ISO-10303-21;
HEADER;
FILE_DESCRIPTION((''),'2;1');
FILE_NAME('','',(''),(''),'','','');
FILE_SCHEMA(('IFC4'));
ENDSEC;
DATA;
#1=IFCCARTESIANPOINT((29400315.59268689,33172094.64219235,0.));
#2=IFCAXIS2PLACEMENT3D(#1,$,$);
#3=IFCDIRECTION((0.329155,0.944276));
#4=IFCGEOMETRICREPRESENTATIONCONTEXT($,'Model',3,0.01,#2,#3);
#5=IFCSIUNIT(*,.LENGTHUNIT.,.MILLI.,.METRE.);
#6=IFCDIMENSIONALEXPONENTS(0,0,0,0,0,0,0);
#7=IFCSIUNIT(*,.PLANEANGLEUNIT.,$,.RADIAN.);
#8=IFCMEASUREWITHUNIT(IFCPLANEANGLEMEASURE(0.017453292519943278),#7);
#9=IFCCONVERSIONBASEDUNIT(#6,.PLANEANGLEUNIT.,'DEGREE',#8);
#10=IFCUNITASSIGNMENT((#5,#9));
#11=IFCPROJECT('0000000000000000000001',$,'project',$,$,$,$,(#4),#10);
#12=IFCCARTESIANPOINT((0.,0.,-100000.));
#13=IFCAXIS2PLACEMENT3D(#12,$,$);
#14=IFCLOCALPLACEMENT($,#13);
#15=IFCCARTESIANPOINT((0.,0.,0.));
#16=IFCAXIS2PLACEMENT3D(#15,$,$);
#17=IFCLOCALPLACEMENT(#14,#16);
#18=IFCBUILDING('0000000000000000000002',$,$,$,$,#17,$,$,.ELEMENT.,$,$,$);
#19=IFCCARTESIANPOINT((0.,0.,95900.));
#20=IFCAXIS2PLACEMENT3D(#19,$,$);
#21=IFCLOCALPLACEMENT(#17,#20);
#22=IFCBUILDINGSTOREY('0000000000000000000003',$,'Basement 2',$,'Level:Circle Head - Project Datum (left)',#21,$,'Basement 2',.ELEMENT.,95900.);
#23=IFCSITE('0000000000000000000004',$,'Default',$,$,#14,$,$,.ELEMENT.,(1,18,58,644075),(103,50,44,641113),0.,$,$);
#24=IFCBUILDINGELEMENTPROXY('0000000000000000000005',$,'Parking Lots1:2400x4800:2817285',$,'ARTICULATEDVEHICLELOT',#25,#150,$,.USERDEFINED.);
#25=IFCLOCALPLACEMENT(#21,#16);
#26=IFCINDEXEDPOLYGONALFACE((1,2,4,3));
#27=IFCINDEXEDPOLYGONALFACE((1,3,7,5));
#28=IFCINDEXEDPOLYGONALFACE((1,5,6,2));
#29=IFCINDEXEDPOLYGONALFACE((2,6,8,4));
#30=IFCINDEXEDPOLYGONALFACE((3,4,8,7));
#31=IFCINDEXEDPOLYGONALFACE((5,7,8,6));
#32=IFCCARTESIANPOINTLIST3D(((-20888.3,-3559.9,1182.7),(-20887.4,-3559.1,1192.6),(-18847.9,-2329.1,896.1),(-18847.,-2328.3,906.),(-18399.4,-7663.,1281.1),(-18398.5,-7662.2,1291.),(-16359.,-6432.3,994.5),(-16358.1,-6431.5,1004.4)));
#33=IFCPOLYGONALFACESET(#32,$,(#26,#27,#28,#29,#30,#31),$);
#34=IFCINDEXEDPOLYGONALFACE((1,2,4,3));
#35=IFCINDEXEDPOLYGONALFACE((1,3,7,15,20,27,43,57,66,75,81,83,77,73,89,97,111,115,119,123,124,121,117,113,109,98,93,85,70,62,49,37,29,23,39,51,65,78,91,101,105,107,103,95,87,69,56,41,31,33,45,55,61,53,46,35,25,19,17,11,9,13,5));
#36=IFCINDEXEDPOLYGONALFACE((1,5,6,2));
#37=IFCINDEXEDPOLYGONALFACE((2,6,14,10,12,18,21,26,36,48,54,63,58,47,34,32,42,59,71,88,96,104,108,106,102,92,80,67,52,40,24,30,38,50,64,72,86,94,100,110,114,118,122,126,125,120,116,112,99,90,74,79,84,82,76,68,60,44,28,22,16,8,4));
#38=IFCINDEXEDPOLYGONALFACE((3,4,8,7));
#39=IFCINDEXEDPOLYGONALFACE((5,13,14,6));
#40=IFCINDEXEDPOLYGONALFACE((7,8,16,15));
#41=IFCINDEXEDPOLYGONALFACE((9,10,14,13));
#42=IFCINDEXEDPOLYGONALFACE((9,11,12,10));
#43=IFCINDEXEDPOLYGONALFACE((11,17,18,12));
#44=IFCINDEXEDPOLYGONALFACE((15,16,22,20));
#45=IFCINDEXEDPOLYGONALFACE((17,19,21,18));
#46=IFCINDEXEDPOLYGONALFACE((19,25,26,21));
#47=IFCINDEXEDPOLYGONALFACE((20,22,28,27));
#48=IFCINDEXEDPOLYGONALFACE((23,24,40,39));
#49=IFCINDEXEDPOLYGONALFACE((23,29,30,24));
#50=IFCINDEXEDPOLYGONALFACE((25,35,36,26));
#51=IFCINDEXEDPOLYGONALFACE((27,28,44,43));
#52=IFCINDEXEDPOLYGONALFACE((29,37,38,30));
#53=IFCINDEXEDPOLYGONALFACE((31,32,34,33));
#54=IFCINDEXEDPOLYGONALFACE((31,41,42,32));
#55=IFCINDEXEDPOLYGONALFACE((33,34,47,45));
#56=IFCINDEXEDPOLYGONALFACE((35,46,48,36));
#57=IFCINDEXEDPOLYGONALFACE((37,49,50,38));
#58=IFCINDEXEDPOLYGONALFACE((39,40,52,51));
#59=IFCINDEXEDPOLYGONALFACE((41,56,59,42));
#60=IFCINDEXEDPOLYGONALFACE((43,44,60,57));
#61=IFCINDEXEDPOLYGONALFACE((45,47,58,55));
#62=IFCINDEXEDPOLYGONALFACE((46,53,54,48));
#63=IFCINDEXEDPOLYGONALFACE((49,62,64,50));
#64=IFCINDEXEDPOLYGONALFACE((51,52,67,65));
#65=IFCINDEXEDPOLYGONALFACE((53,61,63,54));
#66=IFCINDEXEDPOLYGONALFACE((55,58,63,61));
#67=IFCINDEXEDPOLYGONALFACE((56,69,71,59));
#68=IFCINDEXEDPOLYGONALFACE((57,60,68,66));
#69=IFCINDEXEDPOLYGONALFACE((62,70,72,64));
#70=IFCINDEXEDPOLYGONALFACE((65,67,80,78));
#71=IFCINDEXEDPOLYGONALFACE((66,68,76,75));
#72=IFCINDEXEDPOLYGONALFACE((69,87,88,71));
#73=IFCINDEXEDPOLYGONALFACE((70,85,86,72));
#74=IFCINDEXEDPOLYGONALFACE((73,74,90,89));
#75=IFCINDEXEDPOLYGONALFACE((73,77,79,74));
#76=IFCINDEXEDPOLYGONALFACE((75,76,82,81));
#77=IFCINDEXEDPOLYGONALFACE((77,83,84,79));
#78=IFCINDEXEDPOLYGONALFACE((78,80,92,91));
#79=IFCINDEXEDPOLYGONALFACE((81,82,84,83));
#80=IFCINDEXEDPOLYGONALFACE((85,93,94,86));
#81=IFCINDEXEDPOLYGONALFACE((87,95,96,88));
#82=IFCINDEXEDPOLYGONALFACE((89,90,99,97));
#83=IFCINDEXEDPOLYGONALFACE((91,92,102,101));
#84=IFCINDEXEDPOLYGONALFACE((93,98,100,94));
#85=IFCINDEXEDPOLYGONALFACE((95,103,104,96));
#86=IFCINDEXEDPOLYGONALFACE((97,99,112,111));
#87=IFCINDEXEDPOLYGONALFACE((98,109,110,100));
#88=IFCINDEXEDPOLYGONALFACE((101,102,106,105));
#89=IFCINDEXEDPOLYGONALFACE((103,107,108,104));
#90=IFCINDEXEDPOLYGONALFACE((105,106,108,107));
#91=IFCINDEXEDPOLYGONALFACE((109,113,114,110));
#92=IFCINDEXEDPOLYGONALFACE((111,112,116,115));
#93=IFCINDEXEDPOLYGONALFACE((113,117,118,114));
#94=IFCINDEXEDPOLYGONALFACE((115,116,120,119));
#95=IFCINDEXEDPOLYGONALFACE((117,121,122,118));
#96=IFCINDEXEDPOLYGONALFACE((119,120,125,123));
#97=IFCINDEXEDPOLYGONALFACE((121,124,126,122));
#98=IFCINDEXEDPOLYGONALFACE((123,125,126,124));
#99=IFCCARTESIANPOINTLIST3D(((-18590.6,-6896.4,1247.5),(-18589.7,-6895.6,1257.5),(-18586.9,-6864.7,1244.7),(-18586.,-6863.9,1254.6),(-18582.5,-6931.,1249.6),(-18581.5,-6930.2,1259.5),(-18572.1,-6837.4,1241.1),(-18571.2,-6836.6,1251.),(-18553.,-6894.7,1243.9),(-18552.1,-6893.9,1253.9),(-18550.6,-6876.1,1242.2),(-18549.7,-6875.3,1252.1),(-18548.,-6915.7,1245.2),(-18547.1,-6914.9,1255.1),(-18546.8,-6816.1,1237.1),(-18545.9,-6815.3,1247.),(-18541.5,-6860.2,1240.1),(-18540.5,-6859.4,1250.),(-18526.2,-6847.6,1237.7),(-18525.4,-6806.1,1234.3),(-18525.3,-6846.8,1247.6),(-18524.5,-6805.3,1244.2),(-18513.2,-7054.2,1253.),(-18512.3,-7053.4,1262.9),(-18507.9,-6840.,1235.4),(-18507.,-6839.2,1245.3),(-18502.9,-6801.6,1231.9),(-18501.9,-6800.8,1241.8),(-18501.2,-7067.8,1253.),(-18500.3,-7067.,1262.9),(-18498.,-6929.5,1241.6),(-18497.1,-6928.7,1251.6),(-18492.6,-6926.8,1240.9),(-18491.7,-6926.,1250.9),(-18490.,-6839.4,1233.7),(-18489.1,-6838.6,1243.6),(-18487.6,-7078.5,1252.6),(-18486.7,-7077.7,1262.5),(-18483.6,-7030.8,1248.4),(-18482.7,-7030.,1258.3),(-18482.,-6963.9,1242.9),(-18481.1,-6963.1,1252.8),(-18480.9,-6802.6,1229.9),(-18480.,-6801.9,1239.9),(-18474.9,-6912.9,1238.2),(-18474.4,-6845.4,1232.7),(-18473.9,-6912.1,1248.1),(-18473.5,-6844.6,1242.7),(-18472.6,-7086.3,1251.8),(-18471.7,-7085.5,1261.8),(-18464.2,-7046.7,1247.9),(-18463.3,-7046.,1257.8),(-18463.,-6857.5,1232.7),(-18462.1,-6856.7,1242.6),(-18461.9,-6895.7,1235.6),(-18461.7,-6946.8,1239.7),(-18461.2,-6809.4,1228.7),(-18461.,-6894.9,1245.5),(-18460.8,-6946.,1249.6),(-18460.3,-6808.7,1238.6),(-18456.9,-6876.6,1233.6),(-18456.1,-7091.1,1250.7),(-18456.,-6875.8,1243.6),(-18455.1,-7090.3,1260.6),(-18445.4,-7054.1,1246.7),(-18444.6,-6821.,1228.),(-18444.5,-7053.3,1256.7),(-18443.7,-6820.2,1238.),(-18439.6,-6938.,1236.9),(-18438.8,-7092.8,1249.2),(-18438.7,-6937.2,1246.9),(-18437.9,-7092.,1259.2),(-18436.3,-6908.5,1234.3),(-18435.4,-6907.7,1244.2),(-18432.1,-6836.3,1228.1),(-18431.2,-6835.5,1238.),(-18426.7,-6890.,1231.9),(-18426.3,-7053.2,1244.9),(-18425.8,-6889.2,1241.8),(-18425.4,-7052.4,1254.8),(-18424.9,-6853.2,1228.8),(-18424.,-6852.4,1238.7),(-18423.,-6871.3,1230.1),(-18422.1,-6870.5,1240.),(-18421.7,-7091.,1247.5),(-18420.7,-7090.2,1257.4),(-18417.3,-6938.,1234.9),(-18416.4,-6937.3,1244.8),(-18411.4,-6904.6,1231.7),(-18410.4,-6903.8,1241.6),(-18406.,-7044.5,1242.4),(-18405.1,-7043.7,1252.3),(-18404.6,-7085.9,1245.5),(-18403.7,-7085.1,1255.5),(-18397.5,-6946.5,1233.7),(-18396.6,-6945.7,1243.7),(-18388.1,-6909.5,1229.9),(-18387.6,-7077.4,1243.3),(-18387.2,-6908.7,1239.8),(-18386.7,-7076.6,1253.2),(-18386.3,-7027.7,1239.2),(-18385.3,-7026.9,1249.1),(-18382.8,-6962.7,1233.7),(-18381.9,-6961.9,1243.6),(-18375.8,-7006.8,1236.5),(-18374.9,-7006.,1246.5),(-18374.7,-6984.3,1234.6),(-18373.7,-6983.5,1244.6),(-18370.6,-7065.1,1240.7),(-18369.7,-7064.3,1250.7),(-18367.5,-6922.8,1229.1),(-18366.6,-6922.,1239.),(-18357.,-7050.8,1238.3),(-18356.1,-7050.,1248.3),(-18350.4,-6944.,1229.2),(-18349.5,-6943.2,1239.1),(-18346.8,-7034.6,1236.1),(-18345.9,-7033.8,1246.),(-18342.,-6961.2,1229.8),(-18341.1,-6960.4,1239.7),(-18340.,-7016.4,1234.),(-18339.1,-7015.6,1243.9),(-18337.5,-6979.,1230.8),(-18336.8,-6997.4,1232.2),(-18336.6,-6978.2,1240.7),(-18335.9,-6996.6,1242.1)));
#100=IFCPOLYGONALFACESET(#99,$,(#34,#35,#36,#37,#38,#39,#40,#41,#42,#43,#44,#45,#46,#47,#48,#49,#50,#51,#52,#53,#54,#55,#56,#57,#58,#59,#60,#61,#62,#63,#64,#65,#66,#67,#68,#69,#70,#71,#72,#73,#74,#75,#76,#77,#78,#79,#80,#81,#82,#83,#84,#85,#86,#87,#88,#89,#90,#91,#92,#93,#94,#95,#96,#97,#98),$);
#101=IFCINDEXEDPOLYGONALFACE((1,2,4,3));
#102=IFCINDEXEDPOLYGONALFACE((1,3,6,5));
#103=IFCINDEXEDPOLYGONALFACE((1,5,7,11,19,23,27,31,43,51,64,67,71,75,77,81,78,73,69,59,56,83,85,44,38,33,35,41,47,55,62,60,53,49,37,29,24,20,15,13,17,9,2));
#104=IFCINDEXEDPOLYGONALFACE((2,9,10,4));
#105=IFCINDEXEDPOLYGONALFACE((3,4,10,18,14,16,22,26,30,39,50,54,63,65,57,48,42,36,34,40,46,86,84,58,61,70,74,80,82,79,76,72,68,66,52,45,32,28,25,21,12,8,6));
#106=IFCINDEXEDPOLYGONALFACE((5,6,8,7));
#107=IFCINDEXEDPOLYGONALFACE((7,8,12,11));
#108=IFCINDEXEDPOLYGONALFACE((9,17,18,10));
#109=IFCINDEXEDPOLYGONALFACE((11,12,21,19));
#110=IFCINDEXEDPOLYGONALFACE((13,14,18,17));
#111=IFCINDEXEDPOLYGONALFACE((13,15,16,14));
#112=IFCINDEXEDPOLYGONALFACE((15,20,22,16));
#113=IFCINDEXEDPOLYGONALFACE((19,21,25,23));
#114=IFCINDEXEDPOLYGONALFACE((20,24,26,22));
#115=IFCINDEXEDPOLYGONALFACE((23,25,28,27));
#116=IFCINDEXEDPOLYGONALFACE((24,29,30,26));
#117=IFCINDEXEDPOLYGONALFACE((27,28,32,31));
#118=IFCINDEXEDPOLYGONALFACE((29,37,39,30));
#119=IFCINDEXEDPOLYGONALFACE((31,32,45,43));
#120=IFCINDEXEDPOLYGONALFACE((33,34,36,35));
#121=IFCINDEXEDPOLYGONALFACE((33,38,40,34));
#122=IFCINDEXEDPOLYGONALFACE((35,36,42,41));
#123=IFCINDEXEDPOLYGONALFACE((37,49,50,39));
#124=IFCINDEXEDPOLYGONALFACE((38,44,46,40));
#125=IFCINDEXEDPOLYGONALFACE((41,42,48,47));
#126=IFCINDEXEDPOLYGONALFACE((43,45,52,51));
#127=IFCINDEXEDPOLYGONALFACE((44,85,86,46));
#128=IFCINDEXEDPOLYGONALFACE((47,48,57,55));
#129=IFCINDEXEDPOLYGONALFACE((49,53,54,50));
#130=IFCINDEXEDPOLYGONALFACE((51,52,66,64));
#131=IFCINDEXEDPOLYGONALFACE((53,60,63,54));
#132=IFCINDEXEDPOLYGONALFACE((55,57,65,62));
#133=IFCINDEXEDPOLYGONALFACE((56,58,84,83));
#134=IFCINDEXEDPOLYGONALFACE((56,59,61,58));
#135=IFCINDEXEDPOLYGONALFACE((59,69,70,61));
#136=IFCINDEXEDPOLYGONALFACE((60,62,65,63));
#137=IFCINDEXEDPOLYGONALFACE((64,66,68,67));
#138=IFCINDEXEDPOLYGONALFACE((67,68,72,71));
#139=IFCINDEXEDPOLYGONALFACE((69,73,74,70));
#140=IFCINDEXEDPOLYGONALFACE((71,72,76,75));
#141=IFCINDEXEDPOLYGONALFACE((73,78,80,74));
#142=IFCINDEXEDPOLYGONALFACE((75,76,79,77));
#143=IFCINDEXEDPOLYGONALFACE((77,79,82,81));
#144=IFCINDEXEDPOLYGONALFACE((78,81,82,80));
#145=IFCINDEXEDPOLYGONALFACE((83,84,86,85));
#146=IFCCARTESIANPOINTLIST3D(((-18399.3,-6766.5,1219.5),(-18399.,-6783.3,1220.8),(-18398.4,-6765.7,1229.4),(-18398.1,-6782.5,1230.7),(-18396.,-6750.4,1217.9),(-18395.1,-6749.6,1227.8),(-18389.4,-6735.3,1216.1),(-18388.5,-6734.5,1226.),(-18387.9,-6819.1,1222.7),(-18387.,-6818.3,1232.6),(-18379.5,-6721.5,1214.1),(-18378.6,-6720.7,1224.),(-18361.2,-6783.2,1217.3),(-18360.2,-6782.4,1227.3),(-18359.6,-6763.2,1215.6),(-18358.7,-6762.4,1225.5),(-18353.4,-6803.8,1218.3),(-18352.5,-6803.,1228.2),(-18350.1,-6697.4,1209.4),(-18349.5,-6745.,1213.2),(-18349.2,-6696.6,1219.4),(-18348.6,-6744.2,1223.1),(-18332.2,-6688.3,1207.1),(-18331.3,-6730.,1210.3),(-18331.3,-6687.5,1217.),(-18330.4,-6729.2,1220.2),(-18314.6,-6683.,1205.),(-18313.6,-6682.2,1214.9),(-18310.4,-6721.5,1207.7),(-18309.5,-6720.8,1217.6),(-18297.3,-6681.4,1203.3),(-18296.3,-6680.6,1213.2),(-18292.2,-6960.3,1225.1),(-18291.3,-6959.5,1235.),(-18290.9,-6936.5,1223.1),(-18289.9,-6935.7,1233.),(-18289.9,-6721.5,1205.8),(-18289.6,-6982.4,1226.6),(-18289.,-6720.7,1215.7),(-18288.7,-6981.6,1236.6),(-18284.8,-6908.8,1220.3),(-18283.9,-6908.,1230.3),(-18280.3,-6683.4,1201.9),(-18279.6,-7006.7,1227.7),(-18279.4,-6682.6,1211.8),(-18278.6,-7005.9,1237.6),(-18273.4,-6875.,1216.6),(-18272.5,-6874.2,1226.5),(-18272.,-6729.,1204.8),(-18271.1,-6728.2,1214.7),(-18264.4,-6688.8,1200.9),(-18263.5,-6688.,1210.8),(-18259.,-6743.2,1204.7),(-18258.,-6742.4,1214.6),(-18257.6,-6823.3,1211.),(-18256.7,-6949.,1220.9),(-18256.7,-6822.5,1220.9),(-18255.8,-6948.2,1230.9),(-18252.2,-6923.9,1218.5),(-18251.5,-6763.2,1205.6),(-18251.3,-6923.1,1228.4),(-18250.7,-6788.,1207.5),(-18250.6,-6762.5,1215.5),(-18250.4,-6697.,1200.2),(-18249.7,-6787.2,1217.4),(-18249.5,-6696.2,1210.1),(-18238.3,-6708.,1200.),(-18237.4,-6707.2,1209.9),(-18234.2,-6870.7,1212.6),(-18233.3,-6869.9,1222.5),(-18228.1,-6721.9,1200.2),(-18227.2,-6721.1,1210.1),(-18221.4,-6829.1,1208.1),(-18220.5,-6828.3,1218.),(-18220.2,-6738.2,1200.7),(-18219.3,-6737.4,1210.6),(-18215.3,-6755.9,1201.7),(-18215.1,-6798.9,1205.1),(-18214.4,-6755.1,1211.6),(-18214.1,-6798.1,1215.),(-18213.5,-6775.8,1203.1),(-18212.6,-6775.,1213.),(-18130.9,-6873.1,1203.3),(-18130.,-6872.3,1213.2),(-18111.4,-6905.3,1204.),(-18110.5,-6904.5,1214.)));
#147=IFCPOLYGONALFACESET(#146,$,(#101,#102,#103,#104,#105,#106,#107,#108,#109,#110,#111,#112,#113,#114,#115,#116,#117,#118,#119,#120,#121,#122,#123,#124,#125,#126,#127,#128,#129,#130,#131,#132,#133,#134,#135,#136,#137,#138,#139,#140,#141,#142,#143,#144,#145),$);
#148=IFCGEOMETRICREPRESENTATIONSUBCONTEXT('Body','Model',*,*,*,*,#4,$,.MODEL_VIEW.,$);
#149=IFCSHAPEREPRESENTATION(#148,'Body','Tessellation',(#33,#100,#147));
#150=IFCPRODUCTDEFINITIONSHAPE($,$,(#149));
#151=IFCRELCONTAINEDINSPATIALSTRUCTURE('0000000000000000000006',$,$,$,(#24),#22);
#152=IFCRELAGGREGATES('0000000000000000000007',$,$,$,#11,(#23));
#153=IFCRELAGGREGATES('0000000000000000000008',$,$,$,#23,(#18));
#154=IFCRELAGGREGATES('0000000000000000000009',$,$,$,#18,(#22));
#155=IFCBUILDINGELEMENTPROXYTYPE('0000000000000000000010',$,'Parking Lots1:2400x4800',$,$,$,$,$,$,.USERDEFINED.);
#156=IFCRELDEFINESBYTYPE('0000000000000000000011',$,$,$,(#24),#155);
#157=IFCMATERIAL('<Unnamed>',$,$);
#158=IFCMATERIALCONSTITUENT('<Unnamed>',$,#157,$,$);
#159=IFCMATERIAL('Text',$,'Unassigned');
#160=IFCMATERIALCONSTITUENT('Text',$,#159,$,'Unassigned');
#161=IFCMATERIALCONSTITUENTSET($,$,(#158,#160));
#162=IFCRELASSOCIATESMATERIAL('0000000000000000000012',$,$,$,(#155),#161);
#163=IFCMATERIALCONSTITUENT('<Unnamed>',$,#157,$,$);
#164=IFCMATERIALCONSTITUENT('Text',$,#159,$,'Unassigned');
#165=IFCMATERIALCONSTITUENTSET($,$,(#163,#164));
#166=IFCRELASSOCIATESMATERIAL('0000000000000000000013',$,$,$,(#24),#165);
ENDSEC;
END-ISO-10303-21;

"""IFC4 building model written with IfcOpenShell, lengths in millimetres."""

from ifc_helpers import new_model, entity, si_unit, converted_unit, direction, frame, origin, place, context, subcontext, project, spatial, indexed_curve, outline, extrude, source, transform, mapped, material, constituent, constituent_set, type_object, type_shapes, element, save


model = new_model("IFC4")

# Units and contexts
model_context = context("Model", 3, precision=0.01, world=frame((29400315.59268689, 33172094.64219235, 0.0)), true_north=direction((0.329155, 0.944276)))
body_context = subcontext(model_context, "Body", "Model", "MODEL_VIEW")
ifc_project = project(units=[si_unit("LENGTHUNIT", "METRE", prefix="MILLI"), converted_unit("PLANEANGLEUNIT", "DEGREE", entity("IfcPlaneAngleMeasure", 0.017453292519943278), si_unit("PLANEANGLEUNIT", "RADIAN"), dimensions=[0, 0, 0, 0, 0, 0, 0])], contexts=[model_context])

# Site, building, storey
site_placement = place(None, frame((0.0, 0.0, -100000.0)))
site = spatial("IfcSite", under=ifc_project, at=site_placement, Name="Default", CompositionType="ELEMENT", RefLatitude=(1, 18, 58, 644075), RefLongitude=(103, 50, 44, 641113), RefElevation=0.0)
building_placement = place(site_placement, origin())
building = spatial("IfcBuilding", under=site, at=building_placement, CompositionType="ELEMENT")
storey_placement = place(building_placement, frame((0.0, 0.0, 95900.0)))
storey = spatial("IfcBuildingStorey", under=building, at=storey_placement, Name="Basement 2", ObjectType="Level:Circle Head - Project Datum (left)", LongName="Basement 2", CompositionType="ELEMENT", Elevation=95900.0)

# Shared definitions
ifc_material_1 = material(Name="<Unnamed>")

# Building element proxy
ifc_material_2 = material(Name="Text", Category="Unassigned")
ifc_constituent_1 = constituent(ifc_material_1, Name="<Unnamed>")
ifc_constituent_2 = constituent(ifc_material_2, Name="Text", Category="Unassigned")
ifc_constituent_set_1 = constituent_set(constituents=[ifc_constituent_1, ifc_constituent_2])
ifc_constituent_3 = constituent(ifc_material_1, Name="<Unnamed>")
ifc_constituent_4 = constituent(ifc_material_2, Name="Text", Category="Unassigned")
ifc_constituent_set_2 = constituent_set(constituents=[ifc_constituent_3, ifc_constituent_4])
building_element_proxy_type_1 = type_object("IfcBuildingElementProxyType", Name="Parking Lots1:2400x4800", PredefinedType="USERDEFINED", material=ifc_constituent_set_2)
shared_shape_1 = source(origin(), body_context, "Body", "SweptSolid", [
    extrude(outline(indexed_curve([(-1200.0, -2400.0), (1200.0, -2400.0), (1200.0, 2400.0), (-1200.0, 2400.0), (-1200.0, -2400.0)], self_intersect=False)), frame((1200.0, -2400.0, 0.0), z_axis=(0.0, 0.0, 1.0), x_axis=(-1.0, 0.0, 0.0)), (0.0, 0.0, 1.0), 10.0),
    extrude(outline(indexed_curve([(41.2, -119.5), (59.4, -119.5), (76.4, -116.4), (92.1, -110.3), (106.7, -101.0), (119.4, -89.1), (129.4, -75.0), (136.9, -58.7), (141.8, -40.2), (143.8, -19.2), (142.2, 0.6), (136.7, 19.2), (127.6, 36.5), (115.5, 51.5), (101.3, 63.2), (84.9, 71.7), (66.4, 76.9), (39.2, 78.2), (15.6, 71.5), (-3.5, 57.2), (-17.0, 35.7), (-24.5, 55.3), (-36.1, 70.5), (-50.9, 81.2), (-68.4, 87.0), (-88.1, 87.8), (-107.7, 83.0), (-125.9, 72.6), (-141.2, 56.8), (-152.7, 36.8), (-159.5, 13.9), (-160.2, -19.4), (-149.6, -48.7), (-128.2, -72.7), (-96.9, -89.6), (-85.6, -53.4), (-104.7, -43.2), (-117.0, -28.9), (-122.8, -11.5), (-122.2, 8.5), (-115.8, 27.4), (-104.4, 41.3), (-89.5, 49.1), (-72.9, 49.6), (-54.6, 41.4), (-43.6, 24.9), (-39.2, 3.6), (-40.6, -19.0), (-42.1, -24.9), (-5.8, -35.8), (-5.1, -9.0), (2.9, 13.6), (17.7, 30.3), (37.1, 39.7), (59.0, 40.0), (80.6, 31.7), (96.7, 15.8), (105.4, -6.0), (104.9, -32.2), (98.0, -53.3), (86.0, -68.3), (68.1, -77.6), (43.3, -81.6), (41.2, -119.5)], self_intersect=False)), frame((329.1, -4158.0, 10.0), z_axis=(0.0, 0.0, 1.0), x_axis=(0.178774, -0.98389, 0.0)), (0.0, 0.0, 1.0), 10.0),
    extrude(outline(indexed_curve([(-91.6, -150.5), (-91.6, -188.2), (106.2, -188.2), (102.1, -162.2), (92.9, -141.9), (79.3, -122.2), (59.6, -101.6), (32.1, -78.5), (-8.5, -42.4), (-32.9, -15.8), (-45.1, 5.8), (-49.2, 26.9), (-45.4, 45.8), (-33.9, 61.4), (-16.2, 72.0), (6.2, 75.5), (29.7, 72.1), (48.0, 61.8), (59.7, 45.4), (63.8, 23.7), (101.5, 28.4), (92.4, 64.9), (83.8, 79.4), (72.6, 91.5), (59.0, 101.0), (43.3, 107.8), (5.4, 113.2), (-14.8, 111.7), (-32.8, 107.2), (-48.5, 99.6), (-62.0, 89.1), (-72.9, 76.3), (-80.7, 62.0), (-85.3, 46.3), (-86.9, 29.2), (-85.2, 11.2), (-80.2, -6.5), (-71.3, -24.6), (-57.9, -43.5), (-36.6, -66.1), (-3.9, -95.1), (39.4, -131.3), (56.4, -150.5), (-91.6, -150.5)], self_intersect=False)), frame((551.1, -4111.8, 10.0), z_axis=(0.0, 0.0, -1.0), x_axis=(-1.0, 0.0, 0.0)), (0.0, 0.0, -1.0), 10.0),
])
type_shapes(building_element_proxy_type_1, [shared_shape_1])
proxy_1_placement = place(storey_placement, frame((-20888.3, -3559.9, 1182.7), z_axis=(0.091563, 0.079345, 0.992633), x_axis=(0.850154, 0.512815, -0.119412)))
element("IfcBuildingElementProxy", 1, at=proxy_1_placement, inside=storey, type_object=building_element_proxy_type_1, material=ifc_constituent_set_1, Name="Parking Lots1:2400x4800:2817285", ObjectType="ARTICULATEDVEHICLELOT", PredefinedType="USERDEFINED", context=body_context, shape_type="MappedRepresentation", body=[
    mapped(shared_shape_1, transform((0.0, 0.0, 0.0), scale=1.0)),
])

save(model, "model.ifc")
